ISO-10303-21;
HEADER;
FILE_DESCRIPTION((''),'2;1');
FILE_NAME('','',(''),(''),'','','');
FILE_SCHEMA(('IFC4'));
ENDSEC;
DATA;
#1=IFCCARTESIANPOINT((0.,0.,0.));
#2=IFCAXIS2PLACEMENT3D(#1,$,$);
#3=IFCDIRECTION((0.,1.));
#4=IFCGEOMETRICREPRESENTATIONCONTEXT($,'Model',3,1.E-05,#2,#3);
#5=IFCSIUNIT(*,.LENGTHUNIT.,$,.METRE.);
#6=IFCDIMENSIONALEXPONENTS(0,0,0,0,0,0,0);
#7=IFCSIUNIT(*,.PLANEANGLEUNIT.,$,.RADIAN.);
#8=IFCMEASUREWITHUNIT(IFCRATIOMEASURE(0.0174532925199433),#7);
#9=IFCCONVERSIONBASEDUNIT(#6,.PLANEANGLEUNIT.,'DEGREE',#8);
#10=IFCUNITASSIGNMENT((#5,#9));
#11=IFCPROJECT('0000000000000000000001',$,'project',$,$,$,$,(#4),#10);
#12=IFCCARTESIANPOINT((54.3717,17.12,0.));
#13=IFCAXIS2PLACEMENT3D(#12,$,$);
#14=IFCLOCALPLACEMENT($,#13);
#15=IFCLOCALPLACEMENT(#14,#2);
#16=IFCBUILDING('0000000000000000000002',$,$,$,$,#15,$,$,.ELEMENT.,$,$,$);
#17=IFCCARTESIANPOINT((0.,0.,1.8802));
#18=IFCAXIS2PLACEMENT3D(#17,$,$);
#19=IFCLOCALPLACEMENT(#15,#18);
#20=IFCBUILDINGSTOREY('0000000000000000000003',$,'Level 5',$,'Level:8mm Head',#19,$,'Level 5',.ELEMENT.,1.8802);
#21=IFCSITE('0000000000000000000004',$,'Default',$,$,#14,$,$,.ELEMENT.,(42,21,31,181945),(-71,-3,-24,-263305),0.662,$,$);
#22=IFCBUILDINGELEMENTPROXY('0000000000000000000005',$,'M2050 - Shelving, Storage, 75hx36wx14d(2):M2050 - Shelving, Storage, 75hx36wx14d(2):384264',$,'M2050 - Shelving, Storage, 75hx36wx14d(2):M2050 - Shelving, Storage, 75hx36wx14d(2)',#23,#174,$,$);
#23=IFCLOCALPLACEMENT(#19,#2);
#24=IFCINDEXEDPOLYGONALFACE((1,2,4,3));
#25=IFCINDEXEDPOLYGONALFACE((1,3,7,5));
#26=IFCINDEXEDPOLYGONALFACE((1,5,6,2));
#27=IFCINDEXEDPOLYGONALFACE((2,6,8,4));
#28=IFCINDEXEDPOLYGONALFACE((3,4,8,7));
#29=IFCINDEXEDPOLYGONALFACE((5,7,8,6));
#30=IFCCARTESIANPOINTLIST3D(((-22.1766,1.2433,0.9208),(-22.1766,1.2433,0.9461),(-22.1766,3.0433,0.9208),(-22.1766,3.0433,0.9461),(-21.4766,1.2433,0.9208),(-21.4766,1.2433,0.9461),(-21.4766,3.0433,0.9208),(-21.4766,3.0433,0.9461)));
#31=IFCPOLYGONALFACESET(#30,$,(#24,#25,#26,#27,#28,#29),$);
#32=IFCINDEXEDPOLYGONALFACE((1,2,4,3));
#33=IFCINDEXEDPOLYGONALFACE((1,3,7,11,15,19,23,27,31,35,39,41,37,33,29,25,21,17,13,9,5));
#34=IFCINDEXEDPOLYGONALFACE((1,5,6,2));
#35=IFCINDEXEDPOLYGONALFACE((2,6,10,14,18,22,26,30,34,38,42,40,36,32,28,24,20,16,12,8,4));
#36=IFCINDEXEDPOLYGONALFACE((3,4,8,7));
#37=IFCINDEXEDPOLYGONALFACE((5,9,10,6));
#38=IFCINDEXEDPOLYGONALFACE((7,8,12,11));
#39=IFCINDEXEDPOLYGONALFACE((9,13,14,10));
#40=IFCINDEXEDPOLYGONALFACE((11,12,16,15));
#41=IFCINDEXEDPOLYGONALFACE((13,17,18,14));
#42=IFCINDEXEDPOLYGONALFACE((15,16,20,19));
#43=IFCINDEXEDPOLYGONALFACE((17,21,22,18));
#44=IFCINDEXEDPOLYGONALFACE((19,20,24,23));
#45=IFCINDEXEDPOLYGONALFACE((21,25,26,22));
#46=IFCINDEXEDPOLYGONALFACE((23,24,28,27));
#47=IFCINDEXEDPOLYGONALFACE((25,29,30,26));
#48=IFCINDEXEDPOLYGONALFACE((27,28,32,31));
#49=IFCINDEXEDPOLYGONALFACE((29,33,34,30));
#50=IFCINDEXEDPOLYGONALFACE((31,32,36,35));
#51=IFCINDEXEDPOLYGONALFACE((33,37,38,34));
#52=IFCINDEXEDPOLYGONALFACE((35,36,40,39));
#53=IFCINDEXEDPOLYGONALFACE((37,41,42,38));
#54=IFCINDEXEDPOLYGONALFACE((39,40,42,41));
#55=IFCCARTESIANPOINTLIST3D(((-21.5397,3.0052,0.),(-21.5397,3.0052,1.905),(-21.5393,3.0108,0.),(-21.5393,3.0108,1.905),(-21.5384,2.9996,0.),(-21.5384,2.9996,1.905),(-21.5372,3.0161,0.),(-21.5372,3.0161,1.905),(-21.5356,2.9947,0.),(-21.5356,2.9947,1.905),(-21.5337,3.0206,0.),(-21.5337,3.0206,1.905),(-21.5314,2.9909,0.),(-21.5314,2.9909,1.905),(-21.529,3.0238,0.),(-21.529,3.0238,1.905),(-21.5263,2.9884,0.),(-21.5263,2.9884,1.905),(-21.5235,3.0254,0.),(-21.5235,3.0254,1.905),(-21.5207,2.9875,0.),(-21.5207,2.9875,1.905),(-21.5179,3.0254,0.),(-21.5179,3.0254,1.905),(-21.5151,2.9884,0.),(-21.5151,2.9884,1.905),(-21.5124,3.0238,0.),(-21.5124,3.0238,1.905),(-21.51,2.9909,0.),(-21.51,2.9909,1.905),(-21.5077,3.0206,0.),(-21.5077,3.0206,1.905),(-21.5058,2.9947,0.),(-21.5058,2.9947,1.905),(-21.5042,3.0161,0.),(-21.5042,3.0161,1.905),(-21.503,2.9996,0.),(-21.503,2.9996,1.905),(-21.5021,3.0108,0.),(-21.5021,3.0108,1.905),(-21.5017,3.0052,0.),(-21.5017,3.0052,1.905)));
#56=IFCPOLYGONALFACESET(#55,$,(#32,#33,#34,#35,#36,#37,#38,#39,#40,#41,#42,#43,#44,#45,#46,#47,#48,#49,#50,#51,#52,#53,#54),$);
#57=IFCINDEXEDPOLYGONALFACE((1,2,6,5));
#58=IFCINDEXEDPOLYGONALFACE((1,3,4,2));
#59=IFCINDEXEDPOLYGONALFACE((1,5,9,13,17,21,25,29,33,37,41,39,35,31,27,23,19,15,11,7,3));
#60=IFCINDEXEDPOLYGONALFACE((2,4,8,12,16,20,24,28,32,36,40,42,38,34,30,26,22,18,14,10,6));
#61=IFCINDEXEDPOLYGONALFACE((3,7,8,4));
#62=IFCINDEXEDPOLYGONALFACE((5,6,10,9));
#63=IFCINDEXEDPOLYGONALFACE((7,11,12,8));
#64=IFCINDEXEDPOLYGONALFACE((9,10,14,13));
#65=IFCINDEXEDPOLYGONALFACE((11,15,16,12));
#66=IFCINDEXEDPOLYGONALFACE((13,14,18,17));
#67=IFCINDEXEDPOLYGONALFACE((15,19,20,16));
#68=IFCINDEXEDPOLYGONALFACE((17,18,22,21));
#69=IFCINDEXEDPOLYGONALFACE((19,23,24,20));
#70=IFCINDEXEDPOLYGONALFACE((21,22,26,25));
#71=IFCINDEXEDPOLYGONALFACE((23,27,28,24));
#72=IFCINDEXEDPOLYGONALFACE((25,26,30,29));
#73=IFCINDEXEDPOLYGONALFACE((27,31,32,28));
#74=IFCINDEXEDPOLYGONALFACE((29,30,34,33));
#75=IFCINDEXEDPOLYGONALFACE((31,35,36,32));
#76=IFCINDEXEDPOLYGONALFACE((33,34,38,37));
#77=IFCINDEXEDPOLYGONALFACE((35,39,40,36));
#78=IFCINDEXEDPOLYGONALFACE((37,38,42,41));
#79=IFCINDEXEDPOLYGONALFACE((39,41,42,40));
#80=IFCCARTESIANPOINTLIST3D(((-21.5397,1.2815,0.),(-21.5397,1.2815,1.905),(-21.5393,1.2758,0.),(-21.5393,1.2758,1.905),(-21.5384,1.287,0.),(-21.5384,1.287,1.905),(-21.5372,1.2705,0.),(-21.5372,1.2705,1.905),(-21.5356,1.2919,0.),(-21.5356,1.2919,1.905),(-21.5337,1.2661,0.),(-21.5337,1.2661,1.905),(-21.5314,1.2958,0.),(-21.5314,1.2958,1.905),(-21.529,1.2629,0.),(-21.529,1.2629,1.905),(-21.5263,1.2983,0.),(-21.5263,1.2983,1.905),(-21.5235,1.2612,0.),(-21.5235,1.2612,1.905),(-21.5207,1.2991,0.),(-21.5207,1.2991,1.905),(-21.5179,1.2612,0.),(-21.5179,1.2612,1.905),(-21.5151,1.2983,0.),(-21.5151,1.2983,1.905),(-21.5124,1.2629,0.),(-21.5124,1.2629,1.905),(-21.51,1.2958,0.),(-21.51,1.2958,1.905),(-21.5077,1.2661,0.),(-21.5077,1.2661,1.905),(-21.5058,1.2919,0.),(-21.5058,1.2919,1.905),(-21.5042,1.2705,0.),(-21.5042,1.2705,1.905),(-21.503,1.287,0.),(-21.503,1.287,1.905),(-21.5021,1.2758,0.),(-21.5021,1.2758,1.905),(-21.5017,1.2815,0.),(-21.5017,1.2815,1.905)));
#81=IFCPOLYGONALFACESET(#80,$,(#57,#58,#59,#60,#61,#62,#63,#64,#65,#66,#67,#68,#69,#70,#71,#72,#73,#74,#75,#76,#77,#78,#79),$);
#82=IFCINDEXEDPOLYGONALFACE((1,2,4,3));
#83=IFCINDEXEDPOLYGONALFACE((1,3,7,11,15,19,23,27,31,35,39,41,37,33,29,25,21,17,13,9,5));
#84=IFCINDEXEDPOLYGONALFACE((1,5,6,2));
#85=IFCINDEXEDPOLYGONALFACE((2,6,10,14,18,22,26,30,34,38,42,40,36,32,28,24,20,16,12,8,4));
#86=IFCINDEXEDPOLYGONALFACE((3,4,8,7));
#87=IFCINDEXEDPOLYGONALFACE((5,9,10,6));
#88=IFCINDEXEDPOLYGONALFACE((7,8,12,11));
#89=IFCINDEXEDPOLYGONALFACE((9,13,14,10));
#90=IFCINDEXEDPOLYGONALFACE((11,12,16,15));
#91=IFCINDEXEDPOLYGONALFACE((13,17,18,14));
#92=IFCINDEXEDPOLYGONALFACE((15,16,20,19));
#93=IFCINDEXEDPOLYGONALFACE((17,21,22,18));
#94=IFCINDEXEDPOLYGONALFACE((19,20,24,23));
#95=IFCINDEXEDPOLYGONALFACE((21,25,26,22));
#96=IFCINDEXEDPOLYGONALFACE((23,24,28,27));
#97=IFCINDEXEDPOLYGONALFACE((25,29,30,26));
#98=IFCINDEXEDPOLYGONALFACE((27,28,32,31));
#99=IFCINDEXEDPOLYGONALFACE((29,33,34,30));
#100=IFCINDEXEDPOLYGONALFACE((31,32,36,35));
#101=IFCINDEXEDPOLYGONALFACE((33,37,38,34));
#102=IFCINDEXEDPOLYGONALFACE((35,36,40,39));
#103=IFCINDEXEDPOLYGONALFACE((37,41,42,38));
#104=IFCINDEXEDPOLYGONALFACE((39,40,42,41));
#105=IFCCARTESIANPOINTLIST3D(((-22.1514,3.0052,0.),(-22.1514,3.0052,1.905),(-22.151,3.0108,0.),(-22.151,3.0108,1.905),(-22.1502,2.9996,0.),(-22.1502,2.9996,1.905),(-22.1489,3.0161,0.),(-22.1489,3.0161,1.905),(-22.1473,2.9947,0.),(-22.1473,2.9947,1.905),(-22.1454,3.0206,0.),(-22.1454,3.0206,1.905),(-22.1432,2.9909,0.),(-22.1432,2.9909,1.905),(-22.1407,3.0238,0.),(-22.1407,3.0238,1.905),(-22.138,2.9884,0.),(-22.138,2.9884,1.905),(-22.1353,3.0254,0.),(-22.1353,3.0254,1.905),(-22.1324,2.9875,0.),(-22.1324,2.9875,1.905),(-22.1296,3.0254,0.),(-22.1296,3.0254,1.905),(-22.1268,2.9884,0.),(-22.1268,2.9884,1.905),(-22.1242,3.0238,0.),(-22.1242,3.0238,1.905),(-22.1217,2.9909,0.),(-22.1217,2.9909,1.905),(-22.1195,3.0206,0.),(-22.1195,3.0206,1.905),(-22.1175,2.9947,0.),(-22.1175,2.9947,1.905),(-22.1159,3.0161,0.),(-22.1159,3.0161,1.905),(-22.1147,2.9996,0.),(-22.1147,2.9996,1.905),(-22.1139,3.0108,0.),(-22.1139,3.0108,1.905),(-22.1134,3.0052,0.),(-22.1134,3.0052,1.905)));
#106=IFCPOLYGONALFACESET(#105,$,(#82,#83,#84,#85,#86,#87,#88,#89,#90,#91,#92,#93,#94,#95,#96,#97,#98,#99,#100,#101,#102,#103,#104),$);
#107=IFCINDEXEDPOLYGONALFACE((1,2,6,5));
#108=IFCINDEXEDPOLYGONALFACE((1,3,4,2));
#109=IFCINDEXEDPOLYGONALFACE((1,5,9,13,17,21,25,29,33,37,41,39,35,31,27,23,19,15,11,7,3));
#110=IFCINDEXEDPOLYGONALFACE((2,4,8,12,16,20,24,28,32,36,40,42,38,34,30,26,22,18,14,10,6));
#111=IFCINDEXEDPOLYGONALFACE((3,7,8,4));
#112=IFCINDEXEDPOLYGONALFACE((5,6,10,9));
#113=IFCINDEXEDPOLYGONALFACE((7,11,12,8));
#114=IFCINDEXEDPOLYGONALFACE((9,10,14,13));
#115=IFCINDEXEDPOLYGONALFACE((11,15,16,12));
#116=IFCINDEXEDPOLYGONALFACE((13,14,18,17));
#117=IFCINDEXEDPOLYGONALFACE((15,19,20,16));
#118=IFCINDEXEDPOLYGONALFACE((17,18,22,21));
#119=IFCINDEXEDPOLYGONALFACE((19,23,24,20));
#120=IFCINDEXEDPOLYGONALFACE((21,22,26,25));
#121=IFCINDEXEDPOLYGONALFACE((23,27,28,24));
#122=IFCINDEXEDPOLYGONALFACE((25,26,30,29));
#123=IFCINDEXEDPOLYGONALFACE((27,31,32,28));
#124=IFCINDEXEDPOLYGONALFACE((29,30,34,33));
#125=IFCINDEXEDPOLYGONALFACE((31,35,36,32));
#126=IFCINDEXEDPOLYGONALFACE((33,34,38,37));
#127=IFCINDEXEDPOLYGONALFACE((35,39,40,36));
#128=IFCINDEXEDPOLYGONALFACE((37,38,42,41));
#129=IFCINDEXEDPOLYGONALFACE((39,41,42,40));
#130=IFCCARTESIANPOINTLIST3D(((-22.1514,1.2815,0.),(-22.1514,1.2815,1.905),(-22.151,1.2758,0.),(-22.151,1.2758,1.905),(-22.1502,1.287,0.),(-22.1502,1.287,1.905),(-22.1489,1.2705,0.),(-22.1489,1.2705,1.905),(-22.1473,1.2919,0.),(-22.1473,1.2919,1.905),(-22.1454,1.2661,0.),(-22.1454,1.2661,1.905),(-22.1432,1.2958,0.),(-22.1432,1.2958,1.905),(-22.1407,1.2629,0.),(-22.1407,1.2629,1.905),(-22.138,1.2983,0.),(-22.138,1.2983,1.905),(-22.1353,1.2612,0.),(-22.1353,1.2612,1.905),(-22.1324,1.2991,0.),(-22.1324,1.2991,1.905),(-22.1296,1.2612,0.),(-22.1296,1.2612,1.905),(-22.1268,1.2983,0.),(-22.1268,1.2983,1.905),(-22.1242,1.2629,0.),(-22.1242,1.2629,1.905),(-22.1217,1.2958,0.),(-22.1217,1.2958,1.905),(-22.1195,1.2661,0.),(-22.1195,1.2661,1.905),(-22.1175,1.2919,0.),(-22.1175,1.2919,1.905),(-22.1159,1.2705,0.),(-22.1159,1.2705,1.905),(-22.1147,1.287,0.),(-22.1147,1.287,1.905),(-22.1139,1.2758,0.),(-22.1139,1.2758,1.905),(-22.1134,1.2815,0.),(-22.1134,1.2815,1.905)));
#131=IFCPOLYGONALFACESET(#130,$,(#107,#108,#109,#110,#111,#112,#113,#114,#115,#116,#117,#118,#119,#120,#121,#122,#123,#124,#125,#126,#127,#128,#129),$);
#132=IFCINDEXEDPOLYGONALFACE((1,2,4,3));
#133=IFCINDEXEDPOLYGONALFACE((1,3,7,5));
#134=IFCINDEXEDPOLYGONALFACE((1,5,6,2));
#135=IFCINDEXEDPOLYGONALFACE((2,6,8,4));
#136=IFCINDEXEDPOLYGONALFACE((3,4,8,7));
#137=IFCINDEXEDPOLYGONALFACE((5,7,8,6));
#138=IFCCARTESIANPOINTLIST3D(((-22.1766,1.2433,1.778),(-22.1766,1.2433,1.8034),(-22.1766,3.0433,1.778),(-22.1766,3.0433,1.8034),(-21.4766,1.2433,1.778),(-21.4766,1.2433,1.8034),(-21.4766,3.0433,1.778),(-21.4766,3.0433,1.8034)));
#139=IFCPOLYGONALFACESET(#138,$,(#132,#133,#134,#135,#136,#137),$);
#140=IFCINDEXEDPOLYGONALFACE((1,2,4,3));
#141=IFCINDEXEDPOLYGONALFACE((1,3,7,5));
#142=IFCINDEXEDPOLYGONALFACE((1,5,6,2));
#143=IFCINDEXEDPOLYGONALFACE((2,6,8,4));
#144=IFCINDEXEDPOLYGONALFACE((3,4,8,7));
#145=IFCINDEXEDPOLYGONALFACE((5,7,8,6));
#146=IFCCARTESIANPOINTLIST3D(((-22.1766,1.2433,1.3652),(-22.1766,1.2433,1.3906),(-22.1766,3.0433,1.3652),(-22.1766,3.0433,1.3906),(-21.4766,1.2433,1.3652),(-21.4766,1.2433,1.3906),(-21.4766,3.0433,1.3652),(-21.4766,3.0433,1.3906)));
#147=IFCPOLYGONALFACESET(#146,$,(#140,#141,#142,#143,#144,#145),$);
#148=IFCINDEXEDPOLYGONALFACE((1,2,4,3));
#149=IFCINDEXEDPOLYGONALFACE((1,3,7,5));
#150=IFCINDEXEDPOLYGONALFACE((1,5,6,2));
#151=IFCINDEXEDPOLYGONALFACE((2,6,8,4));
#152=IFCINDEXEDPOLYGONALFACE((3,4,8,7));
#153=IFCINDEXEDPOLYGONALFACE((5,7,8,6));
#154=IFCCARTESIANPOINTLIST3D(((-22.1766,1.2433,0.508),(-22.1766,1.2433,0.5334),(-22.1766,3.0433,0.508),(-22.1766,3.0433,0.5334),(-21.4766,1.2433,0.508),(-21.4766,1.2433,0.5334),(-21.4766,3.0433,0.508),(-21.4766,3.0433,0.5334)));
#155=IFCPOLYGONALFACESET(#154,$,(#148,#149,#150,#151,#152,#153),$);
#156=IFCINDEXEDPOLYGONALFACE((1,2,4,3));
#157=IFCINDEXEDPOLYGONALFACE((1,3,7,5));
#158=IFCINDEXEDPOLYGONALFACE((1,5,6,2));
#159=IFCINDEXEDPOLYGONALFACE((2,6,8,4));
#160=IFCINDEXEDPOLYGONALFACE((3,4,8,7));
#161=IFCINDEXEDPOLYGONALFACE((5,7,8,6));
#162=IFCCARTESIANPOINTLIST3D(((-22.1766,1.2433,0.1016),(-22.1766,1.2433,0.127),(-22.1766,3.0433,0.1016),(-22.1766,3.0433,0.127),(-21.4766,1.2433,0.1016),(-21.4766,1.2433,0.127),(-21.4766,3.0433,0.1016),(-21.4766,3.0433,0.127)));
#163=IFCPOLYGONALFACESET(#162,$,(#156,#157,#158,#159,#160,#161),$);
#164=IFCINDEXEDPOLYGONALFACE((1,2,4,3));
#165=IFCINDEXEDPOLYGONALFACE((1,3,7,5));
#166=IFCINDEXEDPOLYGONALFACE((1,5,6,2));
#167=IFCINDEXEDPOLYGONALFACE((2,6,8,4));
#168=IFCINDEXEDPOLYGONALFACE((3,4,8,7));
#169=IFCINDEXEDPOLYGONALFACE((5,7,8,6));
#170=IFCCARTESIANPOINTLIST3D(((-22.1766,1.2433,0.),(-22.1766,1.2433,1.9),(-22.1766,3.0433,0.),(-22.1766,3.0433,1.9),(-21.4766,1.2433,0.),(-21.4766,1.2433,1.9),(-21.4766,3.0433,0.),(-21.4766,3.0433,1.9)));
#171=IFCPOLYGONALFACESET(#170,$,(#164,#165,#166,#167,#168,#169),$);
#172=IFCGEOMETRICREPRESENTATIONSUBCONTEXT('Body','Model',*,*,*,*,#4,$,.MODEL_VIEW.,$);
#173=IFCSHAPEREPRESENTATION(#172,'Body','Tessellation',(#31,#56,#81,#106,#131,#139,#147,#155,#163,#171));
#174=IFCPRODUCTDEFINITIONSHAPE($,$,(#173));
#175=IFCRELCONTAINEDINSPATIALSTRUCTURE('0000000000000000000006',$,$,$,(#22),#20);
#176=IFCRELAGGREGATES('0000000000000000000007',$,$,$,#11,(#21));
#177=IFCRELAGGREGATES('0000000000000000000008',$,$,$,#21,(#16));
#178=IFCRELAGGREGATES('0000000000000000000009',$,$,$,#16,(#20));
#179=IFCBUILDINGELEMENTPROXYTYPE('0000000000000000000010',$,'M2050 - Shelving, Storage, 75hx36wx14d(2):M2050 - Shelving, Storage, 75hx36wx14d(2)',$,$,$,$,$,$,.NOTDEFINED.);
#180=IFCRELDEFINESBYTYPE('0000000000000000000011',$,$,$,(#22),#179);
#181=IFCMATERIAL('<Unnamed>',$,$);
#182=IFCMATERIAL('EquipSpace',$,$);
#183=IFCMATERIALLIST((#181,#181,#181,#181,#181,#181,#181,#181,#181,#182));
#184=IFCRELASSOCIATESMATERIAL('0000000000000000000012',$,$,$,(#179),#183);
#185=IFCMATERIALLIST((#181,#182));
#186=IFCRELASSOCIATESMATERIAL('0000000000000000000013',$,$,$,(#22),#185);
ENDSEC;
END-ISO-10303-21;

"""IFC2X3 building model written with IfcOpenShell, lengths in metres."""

from ifc_helpers import new_model, entity, si_unit, converted_unit, direction, frame, frame_2d, origin, origin_2d_with_axis, place, context, subcontext, project, spatial, rectangle, circle, extrude, source, transform, mapped, material, material_list, type_object, type_shapes, element, save


model = new_model("IFC2X3")

# Units and contexts
model_context = context("Model", 3, precision=1e-05, world=origin(), true_north=direction((0.0, 1.0)))
body_context = subcontext(model_context, "Body", "Model", "MODEL_VIEW")
ifc_project = project(units=[si_unit("LENGTHUNIT", "METRE"), converted_unit("PLANEANGLEUNIT", "DEGREE", entity("IfcRatioMeasure", 0.0174532925199433), si_unit("PLANEANGLEUNIT", "RADIAN"), dimensions=[0, 0, 0, 0, 0, 0, 0])], contexts=[model_context])

# Site, building, storey
site_placement = place(None, frame((54.3717, 17.12, 0.0)))
site = spatial("IfcSite", under=ifc_project, at=site_placement, Name="Default", CompositionType="ELEMENT", RefLatitude=(42, 21, 31, 181945), RefLongitude=(-71, -3, -24, -263305), RefElevation=0.662)
building_placement = place(site_placement, origin())
building = spatial("IfcBuilding", under=site, at=building_placement, CompositionType="ELEMENT")
storey_placement = place(building_placement, frame((0.0, 0.0, 1.8802)))
storey = spatial("IfcBuildingStorey", under=building, at=storey_placement, Name="Level 5", ObjectType="Level:8mm Head", LongName="Level 5", CompositionType="ELEMENT", Elevation=1.8802)

# Building element proxy
ifc_material_1 = material(Name="<Unnamed>")
ifc_material_2 = material(Name="EquipSpace")
ifc_material_list_1 = material_list([ifc_material_1, ifc_material_1, ifc_material_1, ifc_material_1, ifc_material_1, ifc_material_1, ifc_material_1, ifc_material_1, ifc_material_1, ifc_material_2])
building_element_proxy_type = type_object("IfcBuildingElementProxyType", Name="M2050 - Shelving, Storage, 75hx36wx14d(2):M2050 - Shelving, Storage, 75hx36wx14d(2)", PredefinedType="NOTDEFINED", material=ifc_material_list_1)
shared_shape = source(origin(), body_context, "Body", "SweptSolid", [
    extrude(rectangle(XDim=1.8, YDim=0.7, at=origin_2d_with_axis()), frame((0.0, 0.0, 0.9207), z_axis=(0.0, 0.0, 1.0), x_axis=(-1.0, 0.0, 0.0)), (0.0, 0.0, 1.0), 0.0254),
    extrude(circle(Radius=0.0191, at=origin_2d_with_axis()), frame((0.8633, -0.3059, 0.0), z_axis=(0.0, 0.0, 1.0), x_axis=(-1.0, 0.0, 0.0)), (0.0, 0.0, 1.0), 1.905),
    extrude(circle(Radius=0.0191, at=origin_2d_with_axis()), frame((-0.8633, -0.3059, 0.0)), (0.0, 0.0, 1.0), 1.905),
    extrude(circle(Radius=0.0191, at=origin_2d_with_axis()), frame((0.8633, 0.3059, 0.0), z_axis=(0.0, 0.0, 1.0), x_axis=(-1.0, 0.0, 0.0)), (0.0, 0.0, 1.0), 1.905),
    extrude(circle(Radius=0.0191, at=origin_2d_with_axis()), frame((-0.8633, 0.3059, 0.0)), (0.0, 0.0, 1.0), 1.905),
    extrude(rectangle(XDim=1.8, YDim=0.7, at=origin_2d_with_axis()), frame((0.0, 0.0, 1.778), z_axis=(0.0, 0.0, 1.0), x_axis=(-1.0, 0.0, 0.0)), (0.0, 0.0, 1.0), 0.0254),
    extrude(rectangle(XDim=1.8, YDim=0.7, at=origin_2d_with_axis()), frame((0.0, 0.0, 1.3653), z_axis=(0.0, 0.0, 1.0), x_axis=(-1.0, 0.0, 0.0)), (0.0, 0.0, 1.0), 0.0254),
    extrude(rectangle(XDim=1.8, YDim=0.7, at=origin_2d_with_axis()), frame((0.0, 0.0, 0.508), z_axis=(0.0, 0.0, 1.0), x_axis=(-1.0, 0.0, 0.0)), (0.0, 0.0, 1.0), 0.0254),
    extrude(rectangle(XDim=1.8, YDim=0.7, at=origin_2d_with_axis()), frame((0.0, 0.0, 0.1016), z_axis=(0.0, 0.0, 1.0), x_axis=(-1.0, 0.0, 0.0)), (0.0, 0.0, 1.0), 0.0254),
    extrude(rectangle(XDim=0.7, YDim=1.8, at=frame_2d((0.0, 0.18), x_axis=(1.0, 0.0))), frame((-0.18, 0.0, 0.0), z_axis=(0.0, 0.0, 1.0), x_axis=(0.0, -1.0, 0.0)), (0.0, 0.0, 1.0), 1.9),
])
type_shapes(building_element_proxy_type, [shared_shape])
ifc_material_list_2 = material_list([ifc_material_1, ifc_material_2])
proxy_1_placement = place(storey_placement, frame((-21.8266, 2.1433, 0.0), z_axis=(0.0, 0.0, 1.0), x_axis=(0.0, 1.0, 0.0)))
element("IfcBuildingElementProxy", 1, at=proxy_1_placement, inside=storey, type_object=building_element_proxy_type, material=ifc_material_list_2, Name="M2050 - Shelving, Storage, 75hx36wx14d(2):M2050 - Shelving, Storage, 75hx36wx14d(2):384264", ObjectType="M2050 - Shelving, Storage, 75hx36wx14d(2):M2050 - Shelving, Storage, 75hx36wx14d(2)", context=body_context, shape_type="MappedRepresentation", body=[
    mapped(shared_shape, transform((0.0, 0.0, 0.0), scale=1.0)),
])

save(model, "model.ifc")
